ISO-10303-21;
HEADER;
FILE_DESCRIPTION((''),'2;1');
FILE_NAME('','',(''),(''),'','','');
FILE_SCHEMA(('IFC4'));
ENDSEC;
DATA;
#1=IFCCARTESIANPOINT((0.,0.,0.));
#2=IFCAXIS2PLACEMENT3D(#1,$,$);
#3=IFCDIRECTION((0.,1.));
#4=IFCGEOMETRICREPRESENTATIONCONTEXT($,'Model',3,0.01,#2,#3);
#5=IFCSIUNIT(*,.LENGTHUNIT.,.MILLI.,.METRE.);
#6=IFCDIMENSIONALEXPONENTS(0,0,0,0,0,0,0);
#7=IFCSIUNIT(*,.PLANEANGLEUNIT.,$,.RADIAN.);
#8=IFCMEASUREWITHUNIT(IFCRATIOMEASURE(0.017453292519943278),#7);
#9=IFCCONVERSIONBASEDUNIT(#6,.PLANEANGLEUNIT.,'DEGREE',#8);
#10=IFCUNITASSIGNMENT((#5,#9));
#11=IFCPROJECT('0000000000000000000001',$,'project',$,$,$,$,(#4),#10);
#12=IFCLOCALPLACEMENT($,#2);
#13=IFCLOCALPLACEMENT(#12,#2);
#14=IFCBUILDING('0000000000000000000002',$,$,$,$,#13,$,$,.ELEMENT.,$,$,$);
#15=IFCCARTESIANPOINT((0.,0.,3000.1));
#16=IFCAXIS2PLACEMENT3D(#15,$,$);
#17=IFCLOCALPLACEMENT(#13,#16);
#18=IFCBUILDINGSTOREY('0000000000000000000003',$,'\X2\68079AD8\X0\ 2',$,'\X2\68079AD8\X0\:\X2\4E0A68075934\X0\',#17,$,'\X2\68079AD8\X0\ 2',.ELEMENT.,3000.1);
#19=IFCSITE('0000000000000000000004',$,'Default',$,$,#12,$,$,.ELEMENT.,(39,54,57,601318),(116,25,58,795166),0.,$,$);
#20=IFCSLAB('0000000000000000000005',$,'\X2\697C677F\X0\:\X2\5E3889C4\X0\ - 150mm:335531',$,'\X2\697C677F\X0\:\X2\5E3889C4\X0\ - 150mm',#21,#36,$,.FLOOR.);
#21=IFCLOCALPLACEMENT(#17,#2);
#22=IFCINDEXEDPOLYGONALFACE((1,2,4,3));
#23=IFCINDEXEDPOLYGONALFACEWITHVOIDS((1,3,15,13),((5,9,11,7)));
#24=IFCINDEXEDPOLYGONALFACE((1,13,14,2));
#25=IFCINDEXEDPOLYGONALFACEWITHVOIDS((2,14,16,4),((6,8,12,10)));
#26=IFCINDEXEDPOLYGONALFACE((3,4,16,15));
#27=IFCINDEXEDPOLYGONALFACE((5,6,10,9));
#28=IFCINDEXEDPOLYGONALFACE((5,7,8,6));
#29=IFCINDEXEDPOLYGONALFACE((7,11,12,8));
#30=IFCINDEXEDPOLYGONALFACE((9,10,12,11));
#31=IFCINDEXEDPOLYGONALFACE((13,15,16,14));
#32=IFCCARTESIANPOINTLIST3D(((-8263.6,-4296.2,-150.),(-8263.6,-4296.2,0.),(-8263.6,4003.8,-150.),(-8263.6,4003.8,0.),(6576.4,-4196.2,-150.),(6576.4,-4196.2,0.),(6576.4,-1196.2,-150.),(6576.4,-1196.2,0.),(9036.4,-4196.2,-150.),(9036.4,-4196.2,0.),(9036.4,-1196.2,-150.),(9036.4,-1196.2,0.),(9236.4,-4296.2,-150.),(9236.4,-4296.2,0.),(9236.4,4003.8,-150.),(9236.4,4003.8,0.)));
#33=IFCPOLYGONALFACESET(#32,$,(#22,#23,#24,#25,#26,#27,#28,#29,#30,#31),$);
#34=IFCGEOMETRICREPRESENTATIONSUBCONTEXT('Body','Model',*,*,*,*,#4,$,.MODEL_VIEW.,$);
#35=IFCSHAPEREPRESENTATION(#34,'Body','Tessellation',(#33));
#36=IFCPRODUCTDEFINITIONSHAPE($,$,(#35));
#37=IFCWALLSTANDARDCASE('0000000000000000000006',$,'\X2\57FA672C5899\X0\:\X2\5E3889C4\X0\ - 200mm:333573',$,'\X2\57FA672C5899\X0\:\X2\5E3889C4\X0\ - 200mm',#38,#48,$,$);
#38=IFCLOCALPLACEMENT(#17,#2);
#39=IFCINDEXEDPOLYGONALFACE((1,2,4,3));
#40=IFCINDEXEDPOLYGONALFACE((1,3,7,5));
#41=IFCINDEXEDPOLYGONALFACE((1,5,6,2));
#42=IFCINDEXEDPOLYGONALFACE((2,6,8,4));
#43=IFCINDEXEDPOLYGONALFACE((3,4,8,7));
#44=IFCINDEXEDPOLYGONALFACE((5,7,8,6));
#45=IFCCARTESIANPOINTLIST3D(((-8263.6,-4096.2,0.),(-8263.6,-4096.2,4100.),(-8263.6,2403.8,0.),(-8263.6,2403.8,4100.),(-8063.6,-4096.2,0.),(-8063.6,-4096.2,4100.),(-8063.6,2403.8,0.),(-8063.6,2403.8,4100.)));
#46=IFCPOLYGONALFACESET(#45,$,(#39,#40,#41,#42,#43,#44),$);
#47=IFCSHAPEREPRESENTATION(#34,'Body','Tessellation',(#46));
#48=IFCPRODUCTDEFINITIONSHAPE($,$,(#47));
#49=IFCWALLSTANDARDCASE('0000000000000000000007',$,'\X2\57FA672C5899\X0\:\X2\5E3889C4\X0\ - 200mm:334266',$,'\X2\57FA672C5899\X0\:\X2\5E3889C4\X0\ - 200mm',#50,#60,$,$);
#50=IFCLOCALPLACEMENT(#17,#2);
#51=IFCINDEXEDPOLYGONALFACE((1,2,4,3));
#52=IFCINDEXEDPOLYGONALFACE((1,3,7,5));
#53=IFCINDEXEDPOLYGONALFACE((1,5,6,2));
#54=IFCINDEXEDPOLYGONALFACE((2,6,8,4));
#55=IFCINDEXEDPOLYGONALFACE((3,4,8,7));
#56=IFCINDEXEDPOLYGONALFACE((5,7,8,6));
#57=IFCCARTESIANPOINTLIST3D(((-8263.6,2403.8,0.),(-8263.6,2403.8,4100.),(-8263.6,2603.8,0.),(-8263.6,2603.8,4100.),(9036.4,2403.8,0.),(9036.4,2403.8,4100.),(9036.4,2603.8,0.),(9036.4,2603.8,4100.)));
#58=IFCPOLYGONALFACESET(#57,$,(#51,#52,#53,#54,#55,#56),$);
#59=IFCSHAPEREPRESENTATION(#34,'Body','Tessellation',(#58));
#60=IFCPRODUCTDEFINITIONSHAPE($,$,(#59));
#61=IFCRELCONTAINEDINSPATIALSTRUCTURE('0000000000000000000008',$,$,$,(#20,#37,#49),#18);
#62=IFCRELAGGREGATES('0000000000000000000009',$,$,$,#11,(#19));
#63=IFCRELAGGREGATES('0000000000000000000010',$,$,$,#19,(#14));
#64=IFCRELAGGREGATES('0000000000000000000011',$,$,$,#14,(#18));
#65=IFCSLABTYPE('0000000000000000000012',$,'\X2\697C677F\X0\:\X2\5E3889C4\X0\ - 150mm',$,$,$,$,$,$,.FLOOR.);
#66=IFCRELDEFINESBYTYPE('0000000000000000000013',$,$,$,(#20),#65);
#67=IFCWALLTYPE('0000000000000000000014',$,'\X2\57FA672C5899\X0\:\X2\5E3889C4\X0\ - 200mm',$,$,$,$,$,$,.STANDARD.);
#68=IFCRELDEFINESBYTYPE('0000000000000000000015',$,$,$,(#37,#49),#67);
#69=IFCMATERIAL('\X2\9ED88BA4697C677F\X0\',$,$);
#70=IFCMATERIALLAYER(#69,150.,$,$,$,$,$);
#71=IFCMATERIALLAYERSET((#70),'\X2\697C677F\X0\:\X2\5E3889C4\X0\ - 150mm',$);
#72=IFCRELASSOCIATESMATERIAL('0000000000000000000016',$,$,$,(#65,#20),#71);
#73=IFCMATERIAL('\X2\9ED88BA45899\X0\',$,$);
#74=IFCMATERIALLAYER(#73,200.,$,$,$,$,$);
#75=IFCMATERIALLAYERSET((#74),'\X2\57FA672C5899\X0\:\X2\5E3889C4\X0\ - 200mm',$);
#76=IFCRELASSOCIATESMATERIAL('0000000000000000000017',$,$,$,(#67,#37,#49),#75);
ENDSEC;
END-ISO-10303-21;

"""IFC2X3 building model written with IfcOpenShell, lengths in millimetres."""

from ifc_helpers import new_model, entity, si_unit, converted_unit, direction, frame, frame_2d, origin, origin_2d_with_axis, place, context, subcontext, project, spatial, rectangle, extrude, material, layer, layer_set, layer_usage, type_object, element, save


model = new_model("IFC2X3")

# Units and contexts
model_context = context("Model", 3, precision=0.01, world=origin(), true_north=direction((0.0, 1.0)))
body_context = subcontext(model_context, "Body", "Model", "MODEL_VIEW")
ifc_project = project(units=[si_unit("LENGTHUNIT", "METRE", prefix="MILLI"), converted_unit("PLANEANGLEUNIT", "DEGREE", entity("IfcRatioMeasure", 0.017453292519943278), si_unit("PLANEANGLEUNIT", "RADIAN"), dimensions=[0, 0, 0, 0, 0, 0, 0])], contexts=[model_context])

# Site, building, storey
site_placement = place(None, origin())
site = spatial("IfcSite", under=ifc_project, at=site_placement, Name="Default", CompositionType="ELEMENT", RefLatitude=(39, 54, 57, 601318), RefLongitude=(116, 25, 58, 795166), RefElevation=0.0)
building_placement = place(site_placement, origin())
building = spatial("IfcBuilding", under=site, at=building_placement, CompositionType="ELEMENT")
storey_placement = place(building_placement, frame((0.0, 0.0, 3000.1)))
storey = spatial("IfcBuildingStorey", under=building, at=storey_placement, Name="标高 2", ObjectType="标高:上标头", LongName="标高 2", CompositionType="ELEMENT", Elevation=3000.1)

# Slab, opening
ifc_material_1 = material(Name="默认楼板")
ifc_layer_1 = layer(ifc_material_1, 150.0)
ifc_layer_set_1 = layer_set([ifc_layer_1], Name="楼板:常规 - 150mm")
ifc_layer_usage_1 = layer_usage(ifc_layer_set_1, "AXIS3", "POSITIVE", 0.0)
slab_type = type_object("IfcSlabType", Name="楼板:常规 - 150mm", PredefinedType="FLOOR", material=ifc_layer_set_1)
slab_placement = place(storey_placement, frame((-8263.6, -4296.2, -150.0)))
slab = element("IfcSlab", 1, at=slab_placement, inside=storey, type_object=slab_type, material=ifc_layer_usage_1, Name="楼板:常规 - 150mm:335531", ObjectType="楼板:常规 - 150mm", PredefinedType="FLOOR", context=body_context, shape_type="SweptSolid", body=[
    extrude(rectangle(XDim=8300.0, YDim=17500.0, at=frame_2d((0.0, 0.0), x_axis=(0.0, -1.0))), frame((8750.0, 4150.0, 150.0), z_axis=(0.0, 0.0, -1.0), x_axis=(-1.0, 0.0, 0.0)), (0.0, 0.0, 1.0), 150.0),
])
opening_placement = place(slab_placement, origin())
element("IfcOpeningElement", 2, at=opening_placement, cuts=slab, ObjectType="Opening", context=body_context, shape_type="SweptSolid", body=[
    extrude(rectangle(XDim=2460.0, YDim=3000.0, at=origin_2d_with_axis()), frame((16070.0, 1600.0, 0.0), z_axis=(0.0, 0.0, 1.0), x_axis=(-1.0, 0.0, 0.0)), (0.0, 0.0, 1.0), 150.0),
])

# Walls
ifc_material_2 = material(Name="默认墙")
ifc_layer_2 = layer(ifc_material_2, 200.0)
ifc_layer_set_2 = layer_set([ifc_layer_2], Name="基本墙:常规 - 200mm")
ifc_layer_usage_2 = layer_usage(ifc_layer_set_2, "AXIS2", "NEGATIVE", 100.0)
wall_type = type_object("IfcWallType", Name="基本墙:常规 - 200mm", PredefinedType="STANDARD", material=ifc_layer_set_2)
wall_1_placement = place(storey_placement, frame((-8163.6, 2403.8, 0.0), z_axis=(0.0, 0.0, 1.0), x_axis=(0.0, -1.0, 0.0)))
element("IfcWallStandardCase", 3, at=wall_1_placement, inside=storey, type_object=wall_type, material=ifc_layer_usage_2, Name="基本墙:常规 - 200mm:333573", ObjectType="基本墙:常规 - 200mm", context=body_context, shape_type="SweptSolid", body=[
    extrude(rectangle(XDim=6500.0, YDim=200.0, at=frame_2d((3250.0, 0.0), x_axis=(-1.0, 0.0))), origin(), (0.0, 0.0, 1.0), 4100.0),
])
wall_2_placement = place(storey_placement, frame((-8263.6, 2503.8, 0.0)))
element("IfcWallStandardCase", 4, at=wall_2_placement, inside=storey, type_object=wall_type, material=ifc_layer_usage_2, Name="基本墙:常规 - 200mm:334266", ObjectType="基本墙:常规 - 200mm", context=body_context, shape_type="SweptSolid", body=[
    extrude(rectangle(XDim=17300.0, YDim=200.0, at=frame_2d((8650.0, 0.0), x_axis=(-1.0, 0.0))), origin(), (0.0, 0.0, 1.0), 4100.0),
])

save(model, "model.ifc")
